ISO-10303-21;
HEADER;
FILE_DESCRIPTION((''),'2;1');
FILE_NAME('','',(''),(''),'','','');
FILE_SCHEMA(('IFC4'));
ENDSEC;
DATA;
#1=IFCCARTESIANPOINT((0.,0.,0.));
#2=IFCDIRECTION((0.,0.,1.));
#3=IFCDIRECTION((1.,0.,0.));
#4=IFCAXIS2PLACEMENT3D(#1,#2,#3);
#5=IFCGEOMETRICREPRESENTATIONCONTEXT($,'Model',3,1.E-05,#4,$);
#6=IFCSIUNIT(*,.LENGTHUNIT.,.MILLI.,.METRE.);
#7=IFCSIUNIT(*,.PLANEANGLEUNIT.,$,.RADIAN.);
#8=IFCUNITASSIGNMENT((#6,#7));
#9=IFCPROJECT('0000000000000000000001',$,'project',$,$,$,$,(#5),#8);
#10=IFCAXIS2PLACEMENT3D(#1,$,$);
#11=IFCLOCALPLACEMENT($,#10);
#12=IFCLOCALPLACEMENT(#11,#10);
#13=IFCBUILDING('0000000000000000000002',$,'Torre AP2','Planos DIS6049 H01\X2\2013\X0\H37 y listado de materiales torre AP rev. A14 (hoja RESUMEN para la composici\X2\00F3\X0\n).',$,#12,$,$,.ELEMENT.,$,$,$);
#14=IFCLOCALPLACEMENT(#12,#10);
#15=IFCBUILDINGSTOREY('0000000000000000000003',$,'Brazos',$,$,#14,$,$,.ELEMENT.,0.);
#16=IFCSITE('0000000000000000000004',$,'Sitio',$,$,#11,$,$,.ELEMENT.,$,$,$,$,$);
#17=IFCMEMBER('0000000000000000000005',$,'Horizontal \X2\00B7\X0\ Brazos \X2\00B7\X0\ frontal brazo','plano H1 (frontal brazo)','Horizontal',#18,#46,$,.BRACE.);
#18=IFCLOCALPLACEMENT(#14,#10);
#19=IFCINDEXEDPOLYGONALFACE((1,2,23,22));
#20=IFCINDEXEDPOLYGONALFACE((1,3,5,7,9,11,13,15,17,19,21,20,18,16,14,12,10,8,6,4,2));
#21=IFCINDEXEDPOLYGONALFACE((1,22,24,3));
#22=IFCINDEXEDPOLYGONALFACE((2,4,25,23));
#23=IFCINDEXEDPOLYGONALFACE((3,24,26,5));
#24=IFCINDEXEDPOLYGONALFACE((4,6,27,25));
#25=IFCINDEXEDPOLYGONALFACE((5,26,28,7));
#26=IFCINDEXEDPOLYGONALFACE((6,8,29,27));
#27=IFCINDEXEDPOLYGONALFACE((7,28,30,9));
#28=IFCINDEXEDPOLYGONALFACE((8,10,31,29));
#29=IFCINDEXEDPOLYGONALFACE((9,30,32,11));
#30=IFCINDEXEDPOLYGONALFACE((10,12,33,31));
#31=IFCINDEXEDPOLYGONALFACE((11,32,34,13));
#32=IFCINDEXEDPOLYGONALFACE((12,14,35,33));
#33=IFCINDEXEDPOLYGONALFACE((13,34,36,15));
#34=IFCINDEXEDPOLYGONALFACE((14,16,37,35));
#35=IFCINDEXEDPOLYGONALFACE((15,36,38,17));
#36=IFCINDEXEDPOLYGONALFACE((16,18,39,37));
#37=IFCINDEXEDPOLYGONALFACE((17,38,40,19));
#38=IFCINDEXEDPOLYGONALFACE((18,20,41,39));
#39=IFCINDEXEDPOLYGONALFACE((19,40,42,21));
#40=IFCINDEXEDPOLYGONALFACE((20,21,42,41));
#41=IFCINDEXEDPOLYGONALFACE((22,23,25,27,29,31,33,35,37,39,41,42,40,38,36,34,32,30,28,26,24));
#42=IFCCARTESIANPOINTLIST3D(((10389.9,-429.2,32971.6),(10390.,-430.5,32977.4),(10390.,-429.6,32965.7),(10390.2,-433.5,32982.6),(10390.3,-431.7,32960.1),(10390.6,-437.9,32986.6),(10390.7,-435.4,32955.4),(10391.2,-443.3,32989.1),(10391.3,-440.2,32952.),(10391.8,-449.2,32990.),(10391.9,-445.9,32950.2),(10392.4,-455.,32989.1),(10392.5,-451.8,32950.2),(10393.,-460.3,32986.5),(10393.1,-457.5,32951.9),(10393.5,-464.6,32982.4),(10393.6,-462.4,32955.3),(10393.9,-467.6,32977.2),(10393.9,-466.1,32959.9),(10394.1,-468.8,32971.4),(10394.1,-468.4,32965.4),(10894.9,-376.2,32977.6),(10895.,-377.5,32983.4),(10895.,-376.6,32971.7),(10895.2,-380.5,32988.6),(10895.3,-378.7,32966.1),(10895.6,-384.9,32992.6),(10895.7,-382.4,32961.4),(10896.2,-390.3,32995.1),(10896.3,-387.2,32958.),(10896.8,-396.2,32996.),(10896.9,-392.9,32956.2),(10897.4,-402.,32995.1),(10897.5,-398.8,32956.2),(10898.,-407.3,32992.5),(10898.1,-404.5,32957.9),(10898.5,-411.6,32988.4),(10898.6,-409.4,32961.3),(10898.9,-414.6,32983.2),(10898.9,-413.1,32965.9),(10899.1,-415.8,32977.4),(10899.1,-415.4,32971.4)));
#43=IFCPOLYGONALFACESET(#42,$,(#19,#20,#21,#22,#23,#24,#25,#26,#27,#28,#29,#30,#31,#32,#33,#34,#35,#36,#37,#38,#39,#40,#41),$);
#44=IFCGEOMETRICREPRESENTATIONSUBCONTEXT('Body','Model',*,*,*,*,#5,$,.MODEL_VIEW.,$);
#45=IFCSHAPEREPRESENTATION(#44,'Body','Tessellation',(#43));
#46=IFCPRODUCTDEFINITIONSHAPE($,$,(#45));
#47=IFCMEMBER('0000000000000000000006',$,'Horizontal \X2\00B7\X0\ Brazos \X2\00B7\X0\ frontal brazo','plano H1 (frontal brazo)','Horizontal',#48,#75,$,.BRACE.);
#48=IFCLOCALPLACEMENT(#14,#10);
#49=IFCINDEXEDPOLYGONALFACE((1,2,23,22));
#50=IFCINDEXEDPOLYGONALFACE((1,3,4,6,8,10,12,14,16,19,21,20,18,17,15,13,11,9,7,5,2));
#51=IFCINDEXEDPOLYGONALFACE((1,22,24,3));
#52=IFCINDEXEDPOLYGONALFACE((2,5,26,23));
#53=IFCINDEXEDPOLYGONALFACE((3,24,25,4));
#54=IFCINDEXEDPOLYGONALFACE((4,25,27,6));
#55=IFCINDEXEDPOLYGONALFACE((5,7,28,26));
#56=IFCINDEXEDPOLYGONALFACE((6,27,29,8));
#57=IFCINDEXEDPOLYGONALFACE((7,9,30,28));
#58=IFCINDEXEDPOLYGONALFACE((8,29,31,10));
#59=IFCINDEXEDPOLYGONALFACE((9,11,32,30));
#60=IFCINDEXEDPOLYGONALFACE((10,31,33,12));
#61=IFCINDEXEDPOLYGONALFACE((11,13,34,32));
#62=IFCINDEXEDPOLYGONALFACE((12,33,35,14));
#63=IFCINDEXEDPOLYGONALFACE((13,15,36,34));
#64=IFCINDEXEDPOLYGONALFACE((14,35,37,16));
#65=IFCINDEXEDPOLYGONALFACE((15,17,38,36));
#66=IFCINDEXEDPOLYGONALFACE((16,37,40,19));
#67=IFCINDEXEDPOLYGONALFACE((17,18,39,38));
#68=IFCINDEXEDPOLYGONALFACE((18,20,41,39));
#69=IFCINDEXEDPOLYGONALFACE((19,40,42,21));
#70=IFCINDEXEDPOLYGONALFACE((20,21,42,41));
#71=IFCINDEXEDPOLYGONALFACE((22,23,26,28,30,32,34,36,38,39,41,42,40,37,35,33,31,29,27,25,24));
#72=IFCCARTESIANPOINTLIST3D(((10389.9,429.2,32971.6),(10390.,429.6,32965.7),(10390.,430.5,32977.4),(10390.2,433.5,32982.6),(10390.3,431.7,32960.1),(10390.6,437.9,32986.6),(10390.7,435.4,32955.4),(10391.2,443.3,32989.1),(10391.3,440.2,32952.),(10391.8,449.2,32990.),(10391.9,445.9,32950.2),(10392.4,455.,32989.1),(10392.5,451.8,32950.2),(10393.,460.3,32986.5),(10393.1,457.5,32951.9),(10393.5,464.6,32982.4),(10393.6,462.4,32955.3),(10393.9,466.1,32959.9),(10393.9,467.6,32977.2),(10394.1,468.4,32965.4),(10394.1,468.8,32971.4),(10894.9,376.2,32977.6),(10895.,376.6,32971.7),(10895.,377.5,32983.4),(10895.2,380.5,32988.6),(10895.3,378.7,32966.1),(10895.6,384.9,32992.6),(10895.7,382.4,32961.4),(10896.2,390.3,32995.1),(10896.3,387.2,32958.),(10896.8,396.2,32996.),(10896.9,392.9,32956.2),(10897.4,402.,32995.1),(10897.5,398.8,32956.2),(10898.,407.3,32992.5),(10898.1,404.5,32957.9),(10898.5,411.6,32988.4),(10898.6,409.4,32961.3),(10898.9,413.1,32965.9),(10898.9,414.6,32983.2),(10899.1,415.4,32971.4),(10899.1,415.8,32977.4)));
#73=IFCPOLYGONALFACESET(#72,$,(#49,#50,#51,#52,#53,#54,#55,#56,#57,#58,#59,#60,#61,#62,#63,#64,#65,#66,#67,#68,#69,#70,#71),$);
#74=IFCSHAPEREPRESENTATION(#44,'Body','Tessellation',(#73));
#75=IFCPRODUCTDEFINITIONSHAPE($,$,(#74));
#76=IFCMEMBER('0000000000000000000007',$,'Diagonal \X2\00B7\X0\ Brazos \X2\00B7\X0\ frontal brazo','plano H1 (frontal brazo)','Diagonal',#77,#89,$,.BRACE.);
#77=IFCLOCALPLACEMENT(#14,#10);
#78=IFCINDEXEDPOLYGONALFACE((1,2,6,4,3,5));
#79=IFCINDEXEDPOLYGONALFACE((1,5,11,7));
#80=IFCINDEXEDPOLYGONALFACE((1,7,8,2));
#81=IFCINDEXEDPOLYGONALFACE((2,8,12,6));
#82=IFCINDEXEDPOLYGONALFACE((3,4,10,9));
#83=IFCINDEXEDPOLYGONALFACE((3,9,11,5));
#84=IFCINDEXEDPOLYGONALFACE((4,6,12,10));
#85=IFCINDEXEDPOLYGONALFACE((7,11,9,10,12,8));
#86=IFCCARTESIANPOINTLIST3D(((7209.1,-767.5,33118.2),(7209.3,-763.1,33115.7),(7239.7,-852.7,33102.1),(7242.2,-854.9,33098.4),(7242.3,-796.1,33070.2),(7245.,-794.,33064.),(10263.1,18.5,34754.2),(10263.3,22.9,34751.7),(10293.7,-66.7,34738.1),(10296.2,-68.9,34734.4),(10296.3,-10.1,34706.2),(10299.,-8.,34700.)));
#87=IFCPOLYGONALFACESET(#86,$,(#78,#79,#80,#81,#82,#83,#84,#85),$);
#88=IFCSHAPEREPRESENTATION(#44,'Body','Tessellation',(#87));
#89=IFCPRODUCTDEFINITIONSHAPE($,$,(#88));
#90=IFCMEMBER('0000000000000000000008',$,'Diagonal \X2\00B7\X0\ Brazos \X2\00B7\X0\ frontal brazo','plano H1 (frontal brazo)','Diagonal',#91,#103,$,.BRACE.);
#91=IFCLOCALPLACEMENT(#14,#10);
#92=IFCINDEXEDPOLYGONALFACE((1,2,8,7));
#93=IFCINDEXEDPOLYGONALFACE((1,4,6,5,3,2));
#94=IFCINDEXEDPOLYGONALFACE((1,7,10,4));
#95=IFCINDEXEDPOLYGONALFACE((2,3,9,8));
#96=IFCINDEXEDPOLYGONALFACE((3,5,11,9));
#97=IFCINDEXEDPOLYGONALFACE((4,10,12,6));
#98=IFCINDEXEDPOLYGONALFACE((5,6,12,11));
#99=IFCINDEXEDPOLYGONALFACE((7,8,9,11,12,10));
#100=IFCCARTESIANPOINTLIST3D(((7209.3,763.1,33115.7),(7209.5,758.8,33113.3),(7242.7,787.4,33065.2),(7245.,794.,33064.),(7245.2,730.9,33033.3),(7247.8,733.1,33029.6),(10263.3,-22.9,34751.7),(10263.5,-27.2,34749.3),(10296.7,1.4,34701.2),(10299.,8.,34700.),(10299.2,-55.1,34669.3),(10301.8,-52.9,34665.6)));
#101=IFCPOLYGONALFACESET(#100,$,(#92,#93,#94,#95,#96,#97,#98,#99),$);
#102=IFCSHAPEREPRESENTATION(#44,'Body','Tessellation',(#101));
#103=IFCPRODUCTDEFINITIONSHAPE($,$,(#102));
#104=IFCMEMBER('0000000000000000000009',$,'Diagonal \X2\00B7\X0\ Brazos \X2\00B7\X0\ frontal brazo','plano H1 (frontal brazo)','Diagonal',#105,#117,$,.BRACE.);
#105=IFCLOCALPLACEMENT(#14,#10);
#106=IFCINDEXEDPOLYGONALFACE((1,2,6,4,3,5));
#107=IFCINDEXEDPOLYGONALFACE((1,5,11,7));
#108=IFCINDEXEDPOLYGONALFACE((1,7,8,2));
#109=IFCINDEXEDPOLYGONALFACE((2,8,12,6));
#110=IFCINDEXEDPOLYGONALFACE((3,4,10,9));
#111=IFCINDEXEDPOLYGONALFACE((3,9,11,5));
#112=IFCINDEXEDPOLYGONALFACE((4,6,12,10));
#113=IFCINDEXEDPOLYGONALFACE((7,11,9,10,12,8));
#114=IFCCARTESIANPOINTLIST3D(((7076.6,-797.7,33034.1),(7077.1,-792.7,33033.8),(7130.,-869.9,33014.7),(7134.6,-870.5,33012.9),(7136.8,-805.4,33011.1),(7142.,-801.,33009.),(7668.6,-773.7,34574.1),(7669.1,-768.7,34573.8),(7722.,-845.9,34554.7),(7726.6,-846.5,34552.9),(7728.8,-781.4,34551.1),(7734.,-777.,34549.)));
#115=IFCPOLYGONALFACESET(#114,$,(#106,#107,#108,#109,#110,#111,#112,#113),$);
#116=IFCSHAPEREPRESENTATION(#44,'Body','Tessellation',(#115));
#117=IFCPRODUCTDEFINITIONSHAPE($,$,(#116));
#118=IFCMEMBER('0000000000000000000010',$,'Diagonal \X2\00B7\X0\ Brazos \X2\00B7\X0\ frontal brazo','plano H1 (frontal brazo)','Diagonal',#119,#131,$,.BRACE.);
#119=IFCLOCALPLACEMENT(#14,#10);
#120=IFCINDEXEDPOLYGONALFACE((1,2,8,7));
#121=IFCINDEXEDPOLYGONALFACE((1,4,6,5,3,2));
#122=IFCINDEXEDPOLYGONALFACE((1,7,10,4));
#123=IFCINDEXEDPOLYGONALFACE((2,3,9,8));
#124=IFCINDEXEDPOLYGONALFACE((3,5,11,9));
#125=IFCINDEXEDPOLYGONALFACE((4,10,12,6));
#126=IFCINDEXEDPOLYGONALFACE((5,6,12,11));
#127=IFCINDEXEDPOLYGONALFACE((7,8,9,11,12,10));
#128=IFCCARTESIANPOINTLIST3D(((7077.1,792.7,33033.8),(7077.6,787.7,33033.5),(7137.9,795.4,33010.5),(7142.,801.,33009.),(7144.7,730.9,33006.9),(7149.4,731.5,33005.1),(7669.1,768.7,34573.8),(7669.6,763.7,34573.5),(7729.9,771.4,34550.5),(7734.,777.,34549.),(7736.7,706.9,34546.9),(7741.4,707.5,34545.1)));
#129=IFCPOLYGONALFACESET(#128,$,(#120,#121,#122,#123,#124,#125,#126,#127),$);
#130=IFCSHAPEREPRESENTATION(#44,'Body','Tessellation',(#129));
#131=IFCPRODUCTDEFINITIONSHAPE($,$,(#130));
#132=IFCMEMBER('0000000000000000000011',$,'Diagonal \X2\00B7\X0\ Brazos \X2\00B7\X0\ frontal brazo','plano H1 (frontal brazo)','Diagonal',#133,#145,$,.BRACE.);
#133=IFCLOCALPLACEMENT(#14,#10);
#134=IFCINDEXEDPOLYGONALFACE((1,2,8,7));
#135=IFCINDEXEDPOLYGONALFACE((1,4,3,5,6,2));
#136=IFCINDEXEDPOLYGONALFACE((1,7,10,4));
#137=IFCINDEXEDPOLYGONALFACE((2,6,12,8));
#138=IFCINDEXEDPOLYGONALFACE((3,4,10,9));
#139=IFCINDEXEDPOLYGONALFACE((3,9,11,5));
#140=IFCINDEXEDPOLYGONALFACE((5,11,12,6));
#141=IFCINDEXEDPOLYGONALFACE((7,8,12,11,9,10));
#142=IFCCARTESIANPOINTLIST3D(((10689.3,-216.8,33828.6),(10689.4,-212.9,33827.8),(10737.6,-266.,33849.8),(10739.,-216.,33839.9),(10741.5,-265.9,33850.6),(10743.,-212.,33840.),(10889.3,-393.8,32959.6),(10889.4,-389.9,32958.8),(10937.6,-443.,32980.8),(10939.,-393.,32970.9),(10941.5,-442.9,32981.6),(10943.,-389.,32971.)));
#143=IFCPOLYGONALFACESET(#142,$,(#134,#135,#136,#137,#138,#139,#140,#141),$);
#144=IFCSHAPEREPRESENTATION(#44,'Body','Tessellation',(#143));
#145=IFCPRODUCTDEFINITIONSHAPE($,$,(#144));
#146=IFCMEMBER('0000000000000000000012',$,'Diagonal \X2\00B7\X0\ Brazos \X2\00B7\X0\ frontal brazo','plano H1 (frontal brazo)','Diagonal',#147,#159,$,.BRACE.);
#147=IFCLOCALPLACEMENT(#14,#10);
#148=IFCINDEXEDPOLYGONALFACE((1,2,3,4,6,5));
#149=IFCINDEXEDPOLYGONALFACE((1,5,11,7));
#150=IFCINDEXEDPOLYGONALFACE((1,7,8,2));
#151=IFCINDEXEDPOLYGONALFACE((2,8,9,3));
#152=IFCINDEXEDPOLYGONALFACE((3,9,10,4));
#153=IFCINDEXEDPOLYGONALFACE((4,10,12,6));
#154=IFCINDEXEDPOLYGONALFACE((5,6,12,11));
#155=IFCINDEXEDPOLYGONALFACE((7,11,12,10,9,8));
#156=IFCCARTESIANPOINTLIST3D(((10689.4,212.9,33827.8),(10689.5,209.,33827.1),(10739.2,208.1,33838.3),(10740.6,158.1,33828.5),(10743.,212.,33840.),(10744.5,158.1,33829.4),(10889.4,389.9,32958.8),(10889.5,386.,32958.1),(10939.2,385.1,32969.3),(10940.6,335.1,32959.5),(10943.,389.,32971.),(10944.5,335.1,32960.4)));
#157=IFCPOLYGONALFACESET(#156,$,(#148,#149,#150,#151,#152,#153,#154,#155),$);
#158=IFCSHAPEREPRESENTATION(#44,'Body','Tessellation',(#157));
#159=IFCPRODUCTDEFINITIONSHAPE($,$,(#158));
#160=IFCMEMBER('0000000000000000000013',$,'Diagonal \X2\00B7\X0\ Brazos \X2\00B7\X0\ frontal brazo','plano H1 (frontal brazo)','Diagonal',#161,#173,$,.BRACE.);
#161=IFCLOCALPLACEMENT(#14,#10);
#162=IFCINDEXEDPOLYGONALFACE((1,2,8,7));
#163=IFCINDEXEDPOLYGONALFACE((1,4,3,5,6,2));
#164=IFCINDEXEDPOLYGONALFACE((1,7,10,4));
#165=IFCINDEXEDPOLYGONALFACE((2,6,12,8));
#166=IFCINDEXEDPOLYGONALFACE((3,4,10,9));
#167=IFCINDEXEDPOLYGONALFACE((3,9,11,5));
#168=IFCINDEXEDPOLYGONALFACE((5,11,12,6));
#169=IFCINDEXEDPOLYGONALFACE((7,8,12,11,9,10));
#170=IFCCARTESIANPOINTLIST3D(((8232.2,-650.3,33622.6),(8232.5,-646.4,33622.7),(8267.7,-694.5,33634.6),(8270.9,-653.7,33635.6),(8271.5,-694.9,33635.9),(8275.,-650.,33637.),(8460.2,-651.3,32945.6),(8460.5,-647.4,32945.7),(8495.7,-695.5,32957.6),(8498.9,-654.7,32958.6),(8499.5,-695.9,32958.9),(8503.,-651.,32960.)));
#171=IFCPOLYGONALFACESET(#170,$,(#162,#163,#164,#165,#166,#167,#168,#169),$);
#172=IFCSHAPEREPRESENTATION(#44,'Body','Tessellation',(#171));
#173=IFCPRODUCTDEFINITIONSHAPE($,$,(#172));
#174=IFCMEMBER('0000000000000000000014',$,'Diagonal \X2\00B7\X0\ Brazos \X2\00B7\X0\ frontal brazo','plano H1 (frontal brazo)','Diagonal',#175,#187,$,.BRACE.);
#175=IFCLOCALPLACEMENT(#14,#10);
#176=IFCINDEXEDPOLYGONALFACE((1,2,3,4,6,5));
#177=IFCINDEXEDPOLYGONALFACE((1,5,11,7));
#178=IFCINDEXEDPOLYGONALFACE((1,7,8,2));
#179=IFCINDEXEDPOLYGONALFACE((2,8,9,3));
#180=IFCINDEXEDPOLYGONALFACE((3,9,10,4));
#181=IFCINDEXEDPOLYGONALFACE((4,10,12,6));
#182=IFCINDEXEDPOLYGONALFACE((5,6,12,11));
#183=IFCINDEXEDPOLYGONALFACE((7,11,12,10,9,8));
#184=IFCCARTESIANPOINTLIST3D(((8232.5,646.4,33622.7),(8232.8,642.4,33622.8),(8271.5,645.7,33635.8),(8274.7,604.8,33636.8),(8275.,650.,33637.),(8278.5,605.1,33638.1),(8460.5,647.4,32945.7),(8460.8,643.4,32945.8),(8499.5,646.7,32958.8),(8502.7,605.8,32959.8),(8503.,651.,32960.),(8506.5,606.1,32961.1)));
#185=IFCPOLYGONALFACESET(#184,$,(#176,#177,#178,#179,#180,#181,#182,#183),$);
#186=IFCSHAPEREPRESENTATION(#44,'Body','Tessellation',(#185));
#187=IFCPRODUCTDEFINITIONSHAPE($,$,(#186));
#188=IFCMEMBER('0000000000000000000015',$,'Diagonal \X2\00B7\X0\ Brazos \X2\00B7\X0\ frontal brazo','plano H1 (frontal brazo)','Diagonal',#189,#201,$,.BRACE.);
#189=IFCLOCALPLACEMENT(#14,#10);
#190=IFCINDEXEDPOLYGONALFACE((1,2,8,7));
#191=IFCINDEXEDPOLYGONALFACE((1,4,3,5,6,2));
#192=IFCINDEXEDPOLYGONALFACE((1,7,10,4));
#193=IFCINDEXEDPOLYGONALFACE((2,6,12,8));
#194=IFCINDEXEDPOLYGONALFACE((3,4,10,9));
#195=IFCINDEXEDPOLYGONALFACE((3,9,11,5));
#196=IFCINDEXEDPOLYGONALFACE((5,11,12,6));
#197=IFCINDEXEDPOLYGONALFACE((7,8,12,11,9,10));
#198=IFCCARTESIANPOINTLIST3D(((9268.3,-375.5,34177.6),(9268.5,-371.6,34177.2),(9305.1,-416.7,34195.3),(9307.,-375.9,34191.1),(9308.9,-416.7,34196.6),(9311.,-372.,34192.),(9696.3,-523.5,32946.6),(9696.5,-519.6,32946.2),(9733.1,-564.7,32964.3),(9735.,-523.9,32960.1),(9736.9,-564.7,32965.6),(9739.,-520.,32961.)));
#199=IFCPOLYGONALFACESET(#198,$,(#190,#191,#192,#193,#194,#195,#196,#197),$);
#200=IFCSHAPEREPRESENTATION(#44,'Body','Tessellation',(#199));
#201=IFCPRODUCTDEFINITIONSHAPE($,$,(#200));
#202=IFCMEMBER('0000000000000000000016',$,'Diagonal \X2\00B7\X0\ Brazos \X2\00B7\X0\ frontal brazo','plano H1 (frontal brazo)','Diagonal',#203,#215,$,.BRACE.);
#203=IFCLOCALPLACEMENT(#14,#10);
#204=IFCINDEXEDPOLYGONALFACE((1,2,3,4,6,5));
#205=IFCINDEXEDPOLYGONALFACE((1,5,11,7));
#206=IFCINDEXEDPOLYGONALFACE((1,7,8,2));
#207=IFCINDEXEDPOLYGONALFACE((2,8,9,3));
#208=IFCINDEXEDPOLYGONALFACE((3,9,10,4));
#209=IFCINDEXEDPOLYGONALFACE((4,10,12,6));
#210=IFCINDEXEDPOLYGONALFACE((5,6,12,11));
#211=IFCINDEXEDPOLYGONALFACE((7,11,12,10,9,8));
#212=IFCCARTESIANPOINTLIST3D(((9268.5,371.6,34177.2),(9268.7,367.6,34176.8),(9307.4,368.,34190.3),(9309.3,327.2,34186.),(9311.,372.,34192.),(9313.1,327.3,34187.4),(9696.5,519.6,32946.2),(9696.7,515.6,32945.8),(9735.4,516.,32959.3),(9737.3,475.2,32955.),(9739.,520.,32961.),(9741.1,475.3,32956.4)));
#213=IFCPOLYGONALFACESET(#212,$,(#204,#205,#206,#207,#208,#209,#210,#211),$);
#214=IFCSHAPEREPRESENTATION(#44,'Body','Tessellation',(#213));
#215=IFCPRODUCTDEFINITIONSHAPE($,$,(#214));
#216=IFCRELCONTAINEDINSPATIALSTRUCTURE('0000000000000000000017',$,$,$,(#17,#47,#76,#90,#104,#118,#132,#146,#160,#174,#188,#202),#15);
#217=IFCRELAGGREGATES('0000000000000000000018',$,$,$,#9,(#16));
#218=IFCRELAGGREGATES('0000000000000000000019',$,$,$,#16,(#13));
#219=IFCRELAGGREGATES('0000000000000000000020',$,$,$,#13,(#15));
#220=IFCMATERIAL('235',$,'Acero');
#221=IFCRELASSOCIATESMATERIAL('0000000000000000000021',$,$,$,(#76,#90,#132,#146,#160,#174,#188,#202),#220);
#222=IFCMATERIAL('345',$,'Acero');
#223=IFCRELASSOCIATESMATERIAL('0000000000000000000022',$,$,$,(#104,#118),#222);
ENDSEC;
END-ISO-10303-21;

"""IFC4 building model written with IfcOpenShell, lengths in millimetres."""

from ifc_helpers import new_model, si_unit, frame, frame_2d, origin, origin_with_axes, place, context, subcontext, project, spatial, circle, l_section, extrude, material, element, save


model = new_model("IFC4")

# Units and contexts
model_context = context("Model", 3, precision=1e-05, world=origin_with_axes())
body_context = subcontext(model_context, "Body", "Model", "MODEL_VIEW")
ifc_project = project(units=[si_unit("LENGTHUNIT", "METRE", prefix="MILLI"), si_unit("PLANEANGLEUNIT", "RADIAN")], contexts=[model_context])

# Site, building, storey
site_placement = place(None, origin())
site = spatial("IfcSite", under=ifc_project, at=site_placement, Name="Sitio", CompositionType="ELEMENT")
building_placement = place(site_placement, origin())
building = spatial("IfcBuilding", under=site, at=building_placement, Name="Torre AP2", Description="Planos DIS6049 H01–H37 y listado de materiales torre AP rev. A14 (hoja RESUMEN para la composición).", CompositionType="ELEMENT")
storey_placement = place(building_placement, origin())
storey = spatial("IfcBuildingStorey", under=building, at=storey_placement, Name="Brazos", CompositionType="ELEMENT", Elevation=0.0)

# Members
for number, where, z_axis, x_axis, name in (
    (1, (10392.0, -449.0, 32970.0), (0.994468, 0.10437, 0.011815), (-0.104986, 0.991163, 0.081074), "Horizontal · Brazos · frontal brazo"),
    (2, (10392.0, 449.0, 32970.0), (0.994468, -0.10437, 0.011815), (-0.104986, -0.991163, 0.081074), "Horizontal · Brazos · frontal brazo"),
):
    element("IfcMember", number, at=place(storey_placement, frame(where, z_axis=z_axis, x_axis=x_axis)), inside=storey, Name=name, Description="plano H1 (frontal brazo)", ObjectType="Horizontal", PredefinedType="BRACE", context=body_context, shape_type="SweptSolid", body=[
        extrude(circle(Radius=20.0), None, (0.0, 0.0, 1.0), 507.8),
    ])
ifc_material_1 = material(Name="235", Category="Acero")
for number, where, z_axis, x_axis, name in (
    (3, (7245.0, -794.0, 33064.0), (0.859644, 0.221244, 0.460503), (-0.509345, 0.441284, 0.738808), "Diagonal · Brazos · frontal brazo"),
    (4, (7245.0, 794.0, 33064.0), (0.859644, -0.221244, 0.460503), (-0.509345, -0.441284, 0.738808), "Diagonal · Brazos · frontal brazo"),
):
    element("IfcMember", number, at=place(storey_placement, frame(where, z_axis=z_axis, x_axis=x_axis)), inside=storey, material=ifc_material_1, Name=name, Description="plano H1 (frontal brazo)", ObjectType="Diagonal", PredefinedType="BRACE", context=body_context, shape_type="SweptSolid", body=[
        extrude(l_section(Depth=70.0, Width=70.0, Thickness=5.0, at=frame_2d((35.0, 35.0))), None, (0.0, 0.0, 1.0), 3552.6),
    ])
ifc_material_2 = material(Name="345", Category="Acero")
for number, where, z_axis, x_axis, name in (
    (5, (7142.0, -801.0, 33009.0), (0.358779, 0.014545, 0.933309), (-0.927462, 0.118373, 0.354686), "Diagonal · Brazos · frontal brazo"),
    (6, (7142.0, 801.0, 33009.0), (0.358779, -0.014545, 0.933309), (-0.927462, -0.118373, 0.354686), "Diagonal · Brazos · frontal brazo"),
):
    element("IfcMember", number, at=place(storey_placement, frame(where, z_axis=z_axis, x_axis=x_axis)), inside=storey, material=ifc_material_2, Name=name, Description="plano H1 (frontal brazo)", ObjectType="Diagonal", PredefinedType="BRACE", context=body_context, shape_type="SweptSolid", body=[
        extrude(l_section(Depth=70.0, Width=70.0, Thickness=5.0, at=frame_2d((35.0, 35.0))), None, (0.0, 0.0, 1.0), 1650.0),
    ])
for number, where, z_axis, x_axis, name in (
    (7, (10943.0, -389.0, 32971.0), (-0.219994, 0.194695, 0.955875), (-0.975122, -0.016589, -0.221045), "Diagonal · Brazos · frontal brazo"),
    (8, (10943.0, 389.0, 32971.0), (-0.219994, -0.194695, 0.955875), (-0.975122, 0.016589, -0.221045), "Diagonal · Brazos · frontal brazo"),
):
    element("IfcMember", number, at=place(storey_placement, frame(where, z_axis=z_axis, x_axis=x_axis)), inside=storey, material=ifc_material_1, Name=name, Description="plano H1 (frontal brazo)", ObjectType="Diagonal", PredefinedType="BRACE", context=body_context, shape_type="SweptSolid", body=[
        extrude(l_section(Depth=55.0, Width=55.0, Thickness=4.0, at=frame_2d((27.5, 27.5))), None, (0.0, 0.0, 1.0), 909.1),
    ])
for number, where, z_axis, x_axis, name in (
    (9, (8503.0, -651.0, 32960.0), (-0.319166, 0.0014, 0.947698), (-0.944542, 0.081082, -0.318223), "Diagonal · Brazos · frontal brazo"),
    (10, (8503.0, 651.0, 32960.0), (-0.319166, -0.0014, 0.947698), (-0.944542, -0.081082, -0.318223), "Diagonal · Brazos · frontal brazo"),
):
    element("IfcMember", number, at=place(storey_placement, frame(where, z_axis=z_axis, x_axis=x_axis)), inside=storey, material=ifc_material_1, Name=name, Description="plano H1 (frontal brazo)", ObjectType="Diagonal", PredefinedType="BRACE", context=body_context, shape_type="SweptSolid", body=[
        extrude(l_section(Depth=45.0, Width=45.0, Thickness=4.0, at=frame_2d((22.5, 22.5))), None, (0.0, 0.0, 1.0), 714.4),
    ])
for number, where, z_axis, x_axis, name in (
    (11, (9739.0, -520.0, 32961.0), (-0.326304, 0.112834, 0.938506), (-0.944119, 0.009962, -0.329454), "Diagonal · Brazos · frontal brazo"),
    (12, (9739.0, 520.0, 32961.0), (-0.326304, -0.112834, 0.938506), (-0.944119, -0.009962, -0.329454), "Diagonal · Brazos · frontal brazo"),
):
    element("IfcMember", number, at=place(storey_placement, frame(where, z_axis=z_axis, x_axis=x_axis)), inside=storey, material=ifc_material_1, Name=name, Description="plano H1 (frontal brazo)", ObjectType="Diagonal", PredefinedType="BRACE", context=body_context, shape_type="SweptSolid", body=[
        extrude(l_section(Depth=45.0, Width=45.0, Thickness=4.0, at=frame_2d((22.5, 22.5))), None, (0.0, 0.0, 1.0), 1311.7),
    ])

save(model, "model.ifc")
